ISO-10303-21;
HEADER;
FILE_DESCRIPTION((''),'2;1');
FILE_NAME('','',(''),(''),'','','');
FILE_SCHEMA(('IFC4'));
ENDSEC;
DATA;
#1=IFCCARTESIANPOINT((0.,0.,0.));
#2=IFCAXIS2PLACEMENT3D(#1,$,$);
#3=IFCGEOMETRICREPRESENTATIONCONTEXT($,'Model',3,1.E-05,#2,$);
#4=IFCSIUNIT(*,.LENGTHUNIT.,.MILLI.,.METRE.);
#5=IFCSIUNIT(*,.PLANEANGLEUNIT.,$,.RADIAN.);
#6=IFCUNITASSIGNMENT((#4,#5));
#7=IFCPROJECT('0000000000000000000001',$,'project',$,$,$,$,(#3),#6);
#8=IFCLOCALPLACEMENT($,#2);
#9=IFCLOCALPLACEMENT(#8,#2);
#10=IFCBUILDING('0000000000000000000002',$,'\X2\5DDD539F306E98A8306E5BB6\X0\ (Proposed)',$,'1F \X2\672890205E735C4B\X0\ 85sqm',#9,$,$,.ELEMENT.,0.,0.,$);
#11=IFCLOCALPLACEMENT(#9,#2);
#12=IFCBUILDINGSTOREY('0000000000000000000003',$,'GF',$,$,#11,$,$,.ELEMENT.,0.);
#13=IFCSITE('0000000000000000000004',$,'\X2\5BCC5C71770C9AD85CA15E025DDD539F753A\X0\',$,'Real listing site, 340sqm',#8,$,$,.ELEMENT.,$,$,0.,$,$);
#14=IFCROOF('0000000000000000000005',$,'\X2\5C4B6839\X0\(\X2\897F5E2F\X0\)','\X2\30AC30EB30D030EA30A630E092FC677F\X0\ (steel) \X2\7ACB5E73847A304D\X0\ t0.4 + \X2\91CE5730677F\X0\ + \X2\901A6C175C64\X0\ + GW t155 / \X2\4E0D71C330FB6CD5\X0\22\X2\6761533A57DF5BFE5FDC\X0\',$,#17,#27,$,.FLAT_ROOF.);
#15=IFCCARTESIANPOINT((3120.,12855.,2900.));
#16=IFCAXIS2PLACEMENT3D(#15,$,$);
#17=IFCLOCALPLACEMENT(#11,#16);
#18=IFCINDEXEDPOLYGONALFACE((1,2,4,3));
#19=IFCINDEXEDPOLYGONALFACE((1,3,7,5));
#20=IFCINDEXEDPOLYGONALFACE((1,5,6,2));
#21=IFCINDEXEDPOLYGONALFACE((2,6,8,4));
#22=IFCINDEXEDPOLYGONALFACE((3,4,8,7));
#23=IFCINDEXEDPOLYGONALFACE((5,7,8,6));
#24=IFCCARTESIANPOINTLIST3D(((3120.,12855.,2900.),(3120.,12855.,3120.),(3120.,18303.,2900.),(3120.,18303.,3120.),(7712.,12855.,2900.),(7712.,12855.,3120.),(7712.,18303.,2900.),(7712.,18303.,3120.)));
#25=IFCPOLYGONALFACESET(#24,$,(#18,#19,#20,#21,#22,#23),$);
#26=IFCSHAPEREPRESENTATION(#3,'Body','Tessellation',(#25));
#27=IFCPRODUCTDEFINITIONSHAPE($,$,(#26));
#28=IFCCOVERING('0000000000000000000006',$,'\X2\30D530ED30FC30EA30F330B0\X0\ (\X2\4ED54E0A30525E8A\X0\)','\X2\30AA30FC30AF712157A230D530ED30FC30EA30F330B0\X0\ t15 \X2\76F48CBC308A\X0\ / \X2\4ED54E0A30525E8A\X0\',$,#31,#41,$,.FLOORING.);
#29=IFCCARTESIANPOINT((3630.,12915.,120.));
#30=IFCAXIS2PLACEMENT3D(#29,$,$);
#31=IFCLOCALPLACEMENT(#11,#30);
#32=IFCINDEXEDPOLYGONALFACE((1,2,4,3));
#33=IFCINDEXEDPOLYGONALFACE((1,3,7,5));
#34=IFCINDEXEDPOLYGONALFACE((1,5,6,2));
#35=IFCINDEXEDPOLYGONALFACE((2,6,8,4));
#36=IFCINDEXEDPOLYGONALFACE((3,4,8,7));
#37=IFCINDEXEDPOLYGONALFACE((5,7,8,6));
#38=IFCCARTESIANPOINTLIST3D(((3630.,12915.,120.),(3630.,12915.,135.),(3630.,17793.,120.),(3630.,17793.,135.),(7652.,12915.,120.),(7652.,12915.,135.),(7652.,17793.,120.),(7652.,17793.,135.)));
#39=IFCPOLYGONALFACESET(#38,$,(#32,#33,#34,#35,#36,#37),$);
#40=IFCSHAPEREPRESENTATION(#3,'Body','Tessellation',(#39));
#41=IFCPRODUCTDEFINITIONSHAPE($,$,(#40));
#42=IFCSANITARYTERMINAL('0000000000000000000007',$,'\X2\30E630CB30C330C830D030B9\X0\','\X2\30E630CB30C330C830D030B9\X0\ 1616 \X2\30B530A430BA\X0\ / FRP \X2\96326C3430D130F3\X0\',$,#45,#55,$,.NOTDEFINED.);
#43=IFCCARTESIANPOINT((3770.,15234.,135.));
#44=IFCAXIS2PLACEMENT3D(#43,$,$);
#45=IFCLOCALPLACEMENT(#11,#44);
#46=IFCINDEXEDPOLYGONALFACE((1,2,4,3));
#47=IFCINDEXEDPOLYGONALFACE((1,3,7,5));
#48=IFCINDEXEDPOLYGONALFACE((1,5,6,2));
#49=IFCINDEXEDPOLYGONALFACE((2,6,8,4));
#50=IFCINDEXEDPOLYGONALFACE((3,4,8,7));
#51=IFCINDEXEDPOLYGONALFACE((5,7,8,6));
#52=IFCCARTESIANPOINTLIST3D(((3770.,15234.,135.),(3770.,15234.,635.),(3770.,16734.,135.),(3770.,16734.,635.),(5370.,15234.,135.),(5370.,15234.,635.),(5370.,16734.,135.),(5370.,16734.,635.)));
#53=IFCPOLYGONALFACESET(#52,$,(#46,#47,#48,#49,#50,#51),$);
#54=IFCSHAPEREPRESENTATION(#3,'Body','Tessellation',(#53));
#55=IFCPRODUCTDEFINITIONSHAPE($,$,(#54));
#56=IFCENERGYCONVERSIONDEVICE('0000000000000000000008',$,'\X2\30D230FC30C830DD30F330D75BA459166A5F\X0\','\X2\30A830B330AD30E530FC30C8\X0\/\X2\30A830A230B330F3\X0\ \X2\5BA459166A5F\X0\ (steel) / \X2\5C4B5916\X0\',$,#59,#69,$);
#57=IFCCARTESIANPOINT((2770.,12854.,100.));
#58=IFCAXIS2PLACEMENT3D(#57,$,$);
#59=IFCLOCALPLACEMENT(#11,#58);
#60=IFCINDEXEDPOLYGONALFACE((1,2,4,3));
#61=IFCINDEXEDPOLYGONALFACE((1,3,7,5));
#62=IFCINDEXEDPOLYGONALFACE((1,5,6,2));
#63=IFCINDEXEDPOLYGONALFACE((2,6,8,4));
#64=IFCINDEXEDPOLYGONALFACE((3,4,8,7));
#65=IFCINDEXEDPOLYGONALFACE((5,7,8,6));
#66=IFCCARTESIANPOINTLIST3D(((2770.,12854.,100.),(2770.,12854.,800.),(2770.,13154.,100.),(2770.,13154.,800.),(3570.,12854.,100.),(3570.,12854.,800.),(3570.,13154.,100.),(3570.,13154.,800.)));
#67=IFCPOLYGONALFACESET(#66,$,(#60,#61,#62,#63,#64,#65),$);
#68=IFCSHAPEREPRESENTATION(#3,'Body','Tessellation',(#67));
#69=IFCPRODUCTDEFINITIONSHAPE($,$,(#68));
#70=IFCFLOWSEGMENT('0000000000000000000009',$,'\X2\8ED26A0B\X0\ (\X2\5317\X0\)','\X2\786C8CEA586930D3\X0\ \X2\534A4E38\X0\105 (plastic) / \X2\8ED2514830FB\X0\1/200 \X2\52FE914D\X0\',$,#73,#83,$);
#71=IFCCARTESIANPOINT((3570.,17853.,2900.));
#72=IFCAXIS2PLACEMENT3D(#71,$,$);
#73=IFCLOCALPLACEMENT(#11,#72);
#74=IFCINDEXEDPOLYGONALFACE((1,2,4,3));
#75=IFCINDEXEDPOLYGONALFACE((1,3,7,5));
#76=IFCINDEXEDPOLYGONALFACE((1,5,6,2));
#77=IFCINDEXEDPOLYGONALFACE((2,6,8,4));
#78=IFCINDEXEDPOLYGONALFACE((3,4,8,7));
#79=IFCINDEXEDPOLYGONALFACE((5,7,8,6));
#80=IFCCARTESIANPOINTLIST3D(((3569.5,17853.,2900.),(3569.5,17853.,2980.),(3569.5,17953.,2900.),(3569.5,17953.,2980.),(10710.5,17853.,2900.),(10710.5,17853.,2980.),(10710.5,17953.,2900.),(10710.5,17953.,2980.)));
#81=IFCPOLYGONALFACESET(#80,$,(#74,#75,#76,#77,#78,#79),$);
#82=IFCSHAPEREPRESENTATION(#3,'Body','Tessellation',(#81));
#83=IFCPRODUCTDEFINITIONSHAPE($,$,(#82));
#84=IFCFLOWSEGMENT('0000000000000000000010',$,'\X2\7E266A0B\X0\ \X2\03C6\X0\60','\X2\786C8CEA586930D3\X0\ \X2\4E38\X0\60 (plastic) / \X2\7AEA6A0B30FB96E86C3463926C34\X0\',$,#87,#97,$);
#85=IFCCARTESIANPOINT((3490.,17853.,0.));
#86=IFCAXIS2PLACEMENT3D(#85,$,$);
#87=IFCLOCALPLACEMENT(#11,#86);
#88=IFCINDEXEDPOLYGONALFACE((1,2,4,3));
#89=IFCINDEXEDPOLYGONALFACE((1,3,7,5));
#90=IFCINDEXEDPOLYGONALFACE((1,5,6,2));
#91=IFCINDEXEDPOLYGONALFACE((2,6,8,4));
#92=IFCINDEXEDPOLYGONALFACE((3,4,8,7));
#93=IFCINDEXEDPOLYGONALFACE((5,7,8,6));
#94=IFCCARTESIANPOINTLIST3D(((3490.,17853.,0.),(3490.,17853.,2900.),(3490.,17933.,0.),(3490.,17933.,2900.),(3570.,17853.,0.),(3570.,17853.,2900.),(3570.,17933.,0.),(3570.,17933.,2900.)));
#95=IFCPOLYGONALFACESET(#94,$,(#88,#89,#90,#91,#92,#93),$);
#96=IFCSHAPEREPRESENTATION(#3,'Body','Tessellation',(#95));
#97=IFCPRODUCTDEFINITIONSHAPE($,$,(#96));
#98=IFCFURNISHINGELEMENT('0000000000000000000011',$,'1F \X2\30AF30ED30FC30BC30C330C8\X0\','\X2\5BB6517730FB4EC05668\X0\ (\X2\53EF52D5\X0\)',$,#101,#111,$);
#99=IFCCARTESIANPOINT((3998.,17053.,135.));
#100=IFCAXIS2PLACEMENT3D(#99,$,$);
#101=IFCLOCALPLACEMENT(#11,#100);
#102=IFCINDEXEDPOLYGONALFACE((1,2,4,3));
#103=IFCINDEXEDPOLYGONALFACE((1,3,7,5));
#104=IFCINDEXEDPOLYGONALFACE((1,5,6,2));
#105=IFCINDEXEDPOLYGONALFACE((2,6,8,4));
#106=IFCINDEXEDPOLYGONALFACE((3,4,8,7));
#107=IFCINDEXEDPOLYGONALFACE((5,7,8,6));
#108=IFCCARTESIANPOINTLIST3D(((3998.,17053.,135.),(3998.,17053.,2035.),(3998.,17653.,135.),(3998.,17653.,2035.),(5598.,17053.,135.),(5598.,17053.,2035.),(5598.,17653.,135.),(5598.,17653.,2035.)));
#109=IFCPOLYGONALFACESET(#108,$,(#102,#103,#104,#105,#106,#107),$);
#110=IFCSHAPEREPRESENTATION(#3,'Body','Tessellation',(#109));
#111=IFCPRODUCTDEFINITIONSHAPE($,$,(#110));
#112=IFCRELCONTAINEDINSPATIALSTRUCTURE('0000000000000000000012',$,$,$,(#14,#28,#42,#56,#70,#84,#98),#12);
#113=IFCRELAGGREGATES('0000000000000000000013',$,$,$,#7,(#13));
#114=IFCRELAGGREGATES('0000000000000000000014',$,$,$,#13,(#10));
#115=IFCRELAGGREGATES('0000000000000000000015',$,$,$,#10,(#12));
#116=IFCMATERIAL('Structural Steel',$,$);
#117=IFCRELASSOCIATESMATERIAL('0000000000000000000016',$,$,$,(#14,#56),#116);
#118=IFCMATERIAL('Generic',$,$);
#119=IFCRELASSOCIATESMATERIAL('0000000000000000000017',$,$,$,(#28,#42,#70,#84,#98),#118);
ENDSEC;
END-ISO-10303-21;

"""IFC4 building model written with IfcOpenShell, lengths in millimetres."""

from ifc_helpers import new_model, si_unit, frame, frame_2d, origin, place, context, project, spatial, rectangle, extrude, material, element, save


model = new_model("IFC4")

# Units and contexts
model_context = context("Model", 3, precision=1e-05, world=origin())
ifc_project = project(units=[si_unit("LENGTHUNIT", "METRE", prefix="MILLI"), si_unit("PLANEANGLEUNIT", "RADIAN")], contexts=[model_context])

# Site, building, storey
site_placement = place(None, origin())
site = spatial("IfcSite", under=ifc_project, at=site_placement, Name="富山県高岡市川原町", ObjectType="Real listing site, 340sqm", CompositionType="ELEMENT", RefElevation=0.0)
building_placement = place(site_placement, origin())
building = spatial("IfcBuilding", under=site, at=building_placement, Name="川原の風の家 (Proposed)", ObjectType="1F 木造平屋 85sqm", CompositionType="ELEMENT", ElevationOfRefHeight=0.0, ElevationOfTerrain=0.0)
storey_placement = place(building_placement, origin())
storey = spatial("IfcBuildingStorey", under=building, at=storey_placement, Name="GF", CompositionType="ELEMENT", Elevation=0.0)

# Roof
ifc_material_1 = material(Name="Structural Steel")
roof_placement = place(storey_placement, frame((3120.0, 12855.0, 2900.0)))
element("IfcRoof", 1, at=roof_placement, inside=storey, material=ifc_material_1, Name="屋根(西帯)", Description="ガルバリウム鋼板 (steel) 立平葺き t0.4 + 野地板 + 通気層 + GW t155 / 不燃・法22条区域対応", PredefinedType="FLAT_ROOF", context=model_context, shape_type="SweptSolid", body=[
    extrude(rectangle(XDim=4592.0, YDim=5448.0, at=frame_2d((2296.0, 2724.0))), frame((3120.0, 12855.0, 2900.0)), (0.0, 0.0, 1.0), 220.0),
])

# Covering
ifc_material_2 = material(Name="Generic")
covering_placement = place(storey_placement, frame((3630.0, 12915.0, 120.0)))
element("IfcCovering", 2, at=covering_placement, inside=storey, material=ifc_material_2, Name="フローリング (仕上げ床)", Description="オーク無垢フローリング t15 直貼り / 仕上げ床", PredefinedType="FLOORING", context=model_context, shape_type="SweptSolid", body=[
    extrude(rectangle(XDim=4022.0, YDim=4878.0, at=frame_2d((2011.0, 2439.0))), frame((3630.0, 12915.0, 120.0)), (0.0, 0.0, 1.0), 15.0),
])

# Sanitary terminal
sanitary_terminal_placement = place(storey_placement, frame((3770.0, 15234.0, 135.0)))
element("IfcSanitaryTerminal", 3, at=sanitary_terminal_placement, inside=storey, material=ifc_material_2, Name="ユニットバス", Description="ユニットバス 1616 サイズ / FRP 防水パン", PredefinedType="NOTDEFINED", context=model_context, shape_type="SweptSolid", body=[
    extrude(rectangle(XDim=1600.0, YDim=1500.0, at=frame_2d((800.0, 750.0))), frame((3770.0, 15234.0, 135.0)), (0.0, 0.0, 1.0), 500.0),
])

# Energy conversion device
energy_conversion_device_placement = place(storey_placement, frame((2770.0, 12854.0, 100.0)))
element("IfcEnergyConversionDevice", 4, at=energy_conversion_device_placement, inside=storey, material=ifc_material_1, Name="ヒートポンプ室外機", Description="エコキュート/エアコン 室外機 (steel) / 屋外", context=model_context, shape_type="SweptSolid", body=[
    extrude(rectangle(XDim=800.0, YDim=300.0, at=frame_2d((400.0, 150.0))), frame((2770.0, 12854.0, 100.0)), (0.0, 0.0, 1.0), 700.0),
])

# Flow segments
flow_segment_1_placement = place(storey_placement, frame((3570.0, 17853.0, 2900.0)))
element("IfcFlowSegment", 5, at=flow_segment_1_placement, inside=storey, material=ifc_material_2, Name="軒樋 (北)", Description="硬質塩ビ 半丸105 (plastic) / 軒先・1/200 勾配", context=model_context, shape_type="SweptSolid", body=[
    extrude(rectangle(XDim=7141.0, YDim=100.0, at=frame_2d((3570.0, 50.0))), frame((3570.0, 17853.0, 2900.0)), (0.0, 0.0, 1.0), 80.0),
])
flow_segment_2_placement = place(storey_placement, frame((3490.0, 17853.0, 0.0)))
element("IfcFlowSegment", 6, at=flow_segment_2_placement, inside=storey, material=ifc_material_2, Name="縦樋 φ60", Description="硬質塩ビ 丸60 (plastic) / 竪樋・雨水排水", context=model_context, shape_type="SweptSolid", body=[
    extrude(rectangle(XDim=80.0, YDim=80.0, at=frame_2d((40.0, 40.0))), frame((3490.0, 17853.0, 0.0)), (0.0, 0.0, 1.0), 2900.0),
])

# Furnishing element
furnishing_placement = place(storey_placement, frame((3998.0, 17053.0, 135.0)))
element("IfcFurnishingElement", 7, at=furnishing_placement, inside=storey, material=ifc_material_2, Name="1F クローゼット", Description="家具・什器 (可動)", context=model_context, shape_type="SweptSolid", body=[
    extrude(rectangle(XDim=1600.0, YDim=600.0, at=frame_2d((800.0, 300.0))), frame((3998.0, 17053.0, 135.0)), (0.0, 0.0, 1.0), 1900.0),
])

save(model, "model.ifc")
